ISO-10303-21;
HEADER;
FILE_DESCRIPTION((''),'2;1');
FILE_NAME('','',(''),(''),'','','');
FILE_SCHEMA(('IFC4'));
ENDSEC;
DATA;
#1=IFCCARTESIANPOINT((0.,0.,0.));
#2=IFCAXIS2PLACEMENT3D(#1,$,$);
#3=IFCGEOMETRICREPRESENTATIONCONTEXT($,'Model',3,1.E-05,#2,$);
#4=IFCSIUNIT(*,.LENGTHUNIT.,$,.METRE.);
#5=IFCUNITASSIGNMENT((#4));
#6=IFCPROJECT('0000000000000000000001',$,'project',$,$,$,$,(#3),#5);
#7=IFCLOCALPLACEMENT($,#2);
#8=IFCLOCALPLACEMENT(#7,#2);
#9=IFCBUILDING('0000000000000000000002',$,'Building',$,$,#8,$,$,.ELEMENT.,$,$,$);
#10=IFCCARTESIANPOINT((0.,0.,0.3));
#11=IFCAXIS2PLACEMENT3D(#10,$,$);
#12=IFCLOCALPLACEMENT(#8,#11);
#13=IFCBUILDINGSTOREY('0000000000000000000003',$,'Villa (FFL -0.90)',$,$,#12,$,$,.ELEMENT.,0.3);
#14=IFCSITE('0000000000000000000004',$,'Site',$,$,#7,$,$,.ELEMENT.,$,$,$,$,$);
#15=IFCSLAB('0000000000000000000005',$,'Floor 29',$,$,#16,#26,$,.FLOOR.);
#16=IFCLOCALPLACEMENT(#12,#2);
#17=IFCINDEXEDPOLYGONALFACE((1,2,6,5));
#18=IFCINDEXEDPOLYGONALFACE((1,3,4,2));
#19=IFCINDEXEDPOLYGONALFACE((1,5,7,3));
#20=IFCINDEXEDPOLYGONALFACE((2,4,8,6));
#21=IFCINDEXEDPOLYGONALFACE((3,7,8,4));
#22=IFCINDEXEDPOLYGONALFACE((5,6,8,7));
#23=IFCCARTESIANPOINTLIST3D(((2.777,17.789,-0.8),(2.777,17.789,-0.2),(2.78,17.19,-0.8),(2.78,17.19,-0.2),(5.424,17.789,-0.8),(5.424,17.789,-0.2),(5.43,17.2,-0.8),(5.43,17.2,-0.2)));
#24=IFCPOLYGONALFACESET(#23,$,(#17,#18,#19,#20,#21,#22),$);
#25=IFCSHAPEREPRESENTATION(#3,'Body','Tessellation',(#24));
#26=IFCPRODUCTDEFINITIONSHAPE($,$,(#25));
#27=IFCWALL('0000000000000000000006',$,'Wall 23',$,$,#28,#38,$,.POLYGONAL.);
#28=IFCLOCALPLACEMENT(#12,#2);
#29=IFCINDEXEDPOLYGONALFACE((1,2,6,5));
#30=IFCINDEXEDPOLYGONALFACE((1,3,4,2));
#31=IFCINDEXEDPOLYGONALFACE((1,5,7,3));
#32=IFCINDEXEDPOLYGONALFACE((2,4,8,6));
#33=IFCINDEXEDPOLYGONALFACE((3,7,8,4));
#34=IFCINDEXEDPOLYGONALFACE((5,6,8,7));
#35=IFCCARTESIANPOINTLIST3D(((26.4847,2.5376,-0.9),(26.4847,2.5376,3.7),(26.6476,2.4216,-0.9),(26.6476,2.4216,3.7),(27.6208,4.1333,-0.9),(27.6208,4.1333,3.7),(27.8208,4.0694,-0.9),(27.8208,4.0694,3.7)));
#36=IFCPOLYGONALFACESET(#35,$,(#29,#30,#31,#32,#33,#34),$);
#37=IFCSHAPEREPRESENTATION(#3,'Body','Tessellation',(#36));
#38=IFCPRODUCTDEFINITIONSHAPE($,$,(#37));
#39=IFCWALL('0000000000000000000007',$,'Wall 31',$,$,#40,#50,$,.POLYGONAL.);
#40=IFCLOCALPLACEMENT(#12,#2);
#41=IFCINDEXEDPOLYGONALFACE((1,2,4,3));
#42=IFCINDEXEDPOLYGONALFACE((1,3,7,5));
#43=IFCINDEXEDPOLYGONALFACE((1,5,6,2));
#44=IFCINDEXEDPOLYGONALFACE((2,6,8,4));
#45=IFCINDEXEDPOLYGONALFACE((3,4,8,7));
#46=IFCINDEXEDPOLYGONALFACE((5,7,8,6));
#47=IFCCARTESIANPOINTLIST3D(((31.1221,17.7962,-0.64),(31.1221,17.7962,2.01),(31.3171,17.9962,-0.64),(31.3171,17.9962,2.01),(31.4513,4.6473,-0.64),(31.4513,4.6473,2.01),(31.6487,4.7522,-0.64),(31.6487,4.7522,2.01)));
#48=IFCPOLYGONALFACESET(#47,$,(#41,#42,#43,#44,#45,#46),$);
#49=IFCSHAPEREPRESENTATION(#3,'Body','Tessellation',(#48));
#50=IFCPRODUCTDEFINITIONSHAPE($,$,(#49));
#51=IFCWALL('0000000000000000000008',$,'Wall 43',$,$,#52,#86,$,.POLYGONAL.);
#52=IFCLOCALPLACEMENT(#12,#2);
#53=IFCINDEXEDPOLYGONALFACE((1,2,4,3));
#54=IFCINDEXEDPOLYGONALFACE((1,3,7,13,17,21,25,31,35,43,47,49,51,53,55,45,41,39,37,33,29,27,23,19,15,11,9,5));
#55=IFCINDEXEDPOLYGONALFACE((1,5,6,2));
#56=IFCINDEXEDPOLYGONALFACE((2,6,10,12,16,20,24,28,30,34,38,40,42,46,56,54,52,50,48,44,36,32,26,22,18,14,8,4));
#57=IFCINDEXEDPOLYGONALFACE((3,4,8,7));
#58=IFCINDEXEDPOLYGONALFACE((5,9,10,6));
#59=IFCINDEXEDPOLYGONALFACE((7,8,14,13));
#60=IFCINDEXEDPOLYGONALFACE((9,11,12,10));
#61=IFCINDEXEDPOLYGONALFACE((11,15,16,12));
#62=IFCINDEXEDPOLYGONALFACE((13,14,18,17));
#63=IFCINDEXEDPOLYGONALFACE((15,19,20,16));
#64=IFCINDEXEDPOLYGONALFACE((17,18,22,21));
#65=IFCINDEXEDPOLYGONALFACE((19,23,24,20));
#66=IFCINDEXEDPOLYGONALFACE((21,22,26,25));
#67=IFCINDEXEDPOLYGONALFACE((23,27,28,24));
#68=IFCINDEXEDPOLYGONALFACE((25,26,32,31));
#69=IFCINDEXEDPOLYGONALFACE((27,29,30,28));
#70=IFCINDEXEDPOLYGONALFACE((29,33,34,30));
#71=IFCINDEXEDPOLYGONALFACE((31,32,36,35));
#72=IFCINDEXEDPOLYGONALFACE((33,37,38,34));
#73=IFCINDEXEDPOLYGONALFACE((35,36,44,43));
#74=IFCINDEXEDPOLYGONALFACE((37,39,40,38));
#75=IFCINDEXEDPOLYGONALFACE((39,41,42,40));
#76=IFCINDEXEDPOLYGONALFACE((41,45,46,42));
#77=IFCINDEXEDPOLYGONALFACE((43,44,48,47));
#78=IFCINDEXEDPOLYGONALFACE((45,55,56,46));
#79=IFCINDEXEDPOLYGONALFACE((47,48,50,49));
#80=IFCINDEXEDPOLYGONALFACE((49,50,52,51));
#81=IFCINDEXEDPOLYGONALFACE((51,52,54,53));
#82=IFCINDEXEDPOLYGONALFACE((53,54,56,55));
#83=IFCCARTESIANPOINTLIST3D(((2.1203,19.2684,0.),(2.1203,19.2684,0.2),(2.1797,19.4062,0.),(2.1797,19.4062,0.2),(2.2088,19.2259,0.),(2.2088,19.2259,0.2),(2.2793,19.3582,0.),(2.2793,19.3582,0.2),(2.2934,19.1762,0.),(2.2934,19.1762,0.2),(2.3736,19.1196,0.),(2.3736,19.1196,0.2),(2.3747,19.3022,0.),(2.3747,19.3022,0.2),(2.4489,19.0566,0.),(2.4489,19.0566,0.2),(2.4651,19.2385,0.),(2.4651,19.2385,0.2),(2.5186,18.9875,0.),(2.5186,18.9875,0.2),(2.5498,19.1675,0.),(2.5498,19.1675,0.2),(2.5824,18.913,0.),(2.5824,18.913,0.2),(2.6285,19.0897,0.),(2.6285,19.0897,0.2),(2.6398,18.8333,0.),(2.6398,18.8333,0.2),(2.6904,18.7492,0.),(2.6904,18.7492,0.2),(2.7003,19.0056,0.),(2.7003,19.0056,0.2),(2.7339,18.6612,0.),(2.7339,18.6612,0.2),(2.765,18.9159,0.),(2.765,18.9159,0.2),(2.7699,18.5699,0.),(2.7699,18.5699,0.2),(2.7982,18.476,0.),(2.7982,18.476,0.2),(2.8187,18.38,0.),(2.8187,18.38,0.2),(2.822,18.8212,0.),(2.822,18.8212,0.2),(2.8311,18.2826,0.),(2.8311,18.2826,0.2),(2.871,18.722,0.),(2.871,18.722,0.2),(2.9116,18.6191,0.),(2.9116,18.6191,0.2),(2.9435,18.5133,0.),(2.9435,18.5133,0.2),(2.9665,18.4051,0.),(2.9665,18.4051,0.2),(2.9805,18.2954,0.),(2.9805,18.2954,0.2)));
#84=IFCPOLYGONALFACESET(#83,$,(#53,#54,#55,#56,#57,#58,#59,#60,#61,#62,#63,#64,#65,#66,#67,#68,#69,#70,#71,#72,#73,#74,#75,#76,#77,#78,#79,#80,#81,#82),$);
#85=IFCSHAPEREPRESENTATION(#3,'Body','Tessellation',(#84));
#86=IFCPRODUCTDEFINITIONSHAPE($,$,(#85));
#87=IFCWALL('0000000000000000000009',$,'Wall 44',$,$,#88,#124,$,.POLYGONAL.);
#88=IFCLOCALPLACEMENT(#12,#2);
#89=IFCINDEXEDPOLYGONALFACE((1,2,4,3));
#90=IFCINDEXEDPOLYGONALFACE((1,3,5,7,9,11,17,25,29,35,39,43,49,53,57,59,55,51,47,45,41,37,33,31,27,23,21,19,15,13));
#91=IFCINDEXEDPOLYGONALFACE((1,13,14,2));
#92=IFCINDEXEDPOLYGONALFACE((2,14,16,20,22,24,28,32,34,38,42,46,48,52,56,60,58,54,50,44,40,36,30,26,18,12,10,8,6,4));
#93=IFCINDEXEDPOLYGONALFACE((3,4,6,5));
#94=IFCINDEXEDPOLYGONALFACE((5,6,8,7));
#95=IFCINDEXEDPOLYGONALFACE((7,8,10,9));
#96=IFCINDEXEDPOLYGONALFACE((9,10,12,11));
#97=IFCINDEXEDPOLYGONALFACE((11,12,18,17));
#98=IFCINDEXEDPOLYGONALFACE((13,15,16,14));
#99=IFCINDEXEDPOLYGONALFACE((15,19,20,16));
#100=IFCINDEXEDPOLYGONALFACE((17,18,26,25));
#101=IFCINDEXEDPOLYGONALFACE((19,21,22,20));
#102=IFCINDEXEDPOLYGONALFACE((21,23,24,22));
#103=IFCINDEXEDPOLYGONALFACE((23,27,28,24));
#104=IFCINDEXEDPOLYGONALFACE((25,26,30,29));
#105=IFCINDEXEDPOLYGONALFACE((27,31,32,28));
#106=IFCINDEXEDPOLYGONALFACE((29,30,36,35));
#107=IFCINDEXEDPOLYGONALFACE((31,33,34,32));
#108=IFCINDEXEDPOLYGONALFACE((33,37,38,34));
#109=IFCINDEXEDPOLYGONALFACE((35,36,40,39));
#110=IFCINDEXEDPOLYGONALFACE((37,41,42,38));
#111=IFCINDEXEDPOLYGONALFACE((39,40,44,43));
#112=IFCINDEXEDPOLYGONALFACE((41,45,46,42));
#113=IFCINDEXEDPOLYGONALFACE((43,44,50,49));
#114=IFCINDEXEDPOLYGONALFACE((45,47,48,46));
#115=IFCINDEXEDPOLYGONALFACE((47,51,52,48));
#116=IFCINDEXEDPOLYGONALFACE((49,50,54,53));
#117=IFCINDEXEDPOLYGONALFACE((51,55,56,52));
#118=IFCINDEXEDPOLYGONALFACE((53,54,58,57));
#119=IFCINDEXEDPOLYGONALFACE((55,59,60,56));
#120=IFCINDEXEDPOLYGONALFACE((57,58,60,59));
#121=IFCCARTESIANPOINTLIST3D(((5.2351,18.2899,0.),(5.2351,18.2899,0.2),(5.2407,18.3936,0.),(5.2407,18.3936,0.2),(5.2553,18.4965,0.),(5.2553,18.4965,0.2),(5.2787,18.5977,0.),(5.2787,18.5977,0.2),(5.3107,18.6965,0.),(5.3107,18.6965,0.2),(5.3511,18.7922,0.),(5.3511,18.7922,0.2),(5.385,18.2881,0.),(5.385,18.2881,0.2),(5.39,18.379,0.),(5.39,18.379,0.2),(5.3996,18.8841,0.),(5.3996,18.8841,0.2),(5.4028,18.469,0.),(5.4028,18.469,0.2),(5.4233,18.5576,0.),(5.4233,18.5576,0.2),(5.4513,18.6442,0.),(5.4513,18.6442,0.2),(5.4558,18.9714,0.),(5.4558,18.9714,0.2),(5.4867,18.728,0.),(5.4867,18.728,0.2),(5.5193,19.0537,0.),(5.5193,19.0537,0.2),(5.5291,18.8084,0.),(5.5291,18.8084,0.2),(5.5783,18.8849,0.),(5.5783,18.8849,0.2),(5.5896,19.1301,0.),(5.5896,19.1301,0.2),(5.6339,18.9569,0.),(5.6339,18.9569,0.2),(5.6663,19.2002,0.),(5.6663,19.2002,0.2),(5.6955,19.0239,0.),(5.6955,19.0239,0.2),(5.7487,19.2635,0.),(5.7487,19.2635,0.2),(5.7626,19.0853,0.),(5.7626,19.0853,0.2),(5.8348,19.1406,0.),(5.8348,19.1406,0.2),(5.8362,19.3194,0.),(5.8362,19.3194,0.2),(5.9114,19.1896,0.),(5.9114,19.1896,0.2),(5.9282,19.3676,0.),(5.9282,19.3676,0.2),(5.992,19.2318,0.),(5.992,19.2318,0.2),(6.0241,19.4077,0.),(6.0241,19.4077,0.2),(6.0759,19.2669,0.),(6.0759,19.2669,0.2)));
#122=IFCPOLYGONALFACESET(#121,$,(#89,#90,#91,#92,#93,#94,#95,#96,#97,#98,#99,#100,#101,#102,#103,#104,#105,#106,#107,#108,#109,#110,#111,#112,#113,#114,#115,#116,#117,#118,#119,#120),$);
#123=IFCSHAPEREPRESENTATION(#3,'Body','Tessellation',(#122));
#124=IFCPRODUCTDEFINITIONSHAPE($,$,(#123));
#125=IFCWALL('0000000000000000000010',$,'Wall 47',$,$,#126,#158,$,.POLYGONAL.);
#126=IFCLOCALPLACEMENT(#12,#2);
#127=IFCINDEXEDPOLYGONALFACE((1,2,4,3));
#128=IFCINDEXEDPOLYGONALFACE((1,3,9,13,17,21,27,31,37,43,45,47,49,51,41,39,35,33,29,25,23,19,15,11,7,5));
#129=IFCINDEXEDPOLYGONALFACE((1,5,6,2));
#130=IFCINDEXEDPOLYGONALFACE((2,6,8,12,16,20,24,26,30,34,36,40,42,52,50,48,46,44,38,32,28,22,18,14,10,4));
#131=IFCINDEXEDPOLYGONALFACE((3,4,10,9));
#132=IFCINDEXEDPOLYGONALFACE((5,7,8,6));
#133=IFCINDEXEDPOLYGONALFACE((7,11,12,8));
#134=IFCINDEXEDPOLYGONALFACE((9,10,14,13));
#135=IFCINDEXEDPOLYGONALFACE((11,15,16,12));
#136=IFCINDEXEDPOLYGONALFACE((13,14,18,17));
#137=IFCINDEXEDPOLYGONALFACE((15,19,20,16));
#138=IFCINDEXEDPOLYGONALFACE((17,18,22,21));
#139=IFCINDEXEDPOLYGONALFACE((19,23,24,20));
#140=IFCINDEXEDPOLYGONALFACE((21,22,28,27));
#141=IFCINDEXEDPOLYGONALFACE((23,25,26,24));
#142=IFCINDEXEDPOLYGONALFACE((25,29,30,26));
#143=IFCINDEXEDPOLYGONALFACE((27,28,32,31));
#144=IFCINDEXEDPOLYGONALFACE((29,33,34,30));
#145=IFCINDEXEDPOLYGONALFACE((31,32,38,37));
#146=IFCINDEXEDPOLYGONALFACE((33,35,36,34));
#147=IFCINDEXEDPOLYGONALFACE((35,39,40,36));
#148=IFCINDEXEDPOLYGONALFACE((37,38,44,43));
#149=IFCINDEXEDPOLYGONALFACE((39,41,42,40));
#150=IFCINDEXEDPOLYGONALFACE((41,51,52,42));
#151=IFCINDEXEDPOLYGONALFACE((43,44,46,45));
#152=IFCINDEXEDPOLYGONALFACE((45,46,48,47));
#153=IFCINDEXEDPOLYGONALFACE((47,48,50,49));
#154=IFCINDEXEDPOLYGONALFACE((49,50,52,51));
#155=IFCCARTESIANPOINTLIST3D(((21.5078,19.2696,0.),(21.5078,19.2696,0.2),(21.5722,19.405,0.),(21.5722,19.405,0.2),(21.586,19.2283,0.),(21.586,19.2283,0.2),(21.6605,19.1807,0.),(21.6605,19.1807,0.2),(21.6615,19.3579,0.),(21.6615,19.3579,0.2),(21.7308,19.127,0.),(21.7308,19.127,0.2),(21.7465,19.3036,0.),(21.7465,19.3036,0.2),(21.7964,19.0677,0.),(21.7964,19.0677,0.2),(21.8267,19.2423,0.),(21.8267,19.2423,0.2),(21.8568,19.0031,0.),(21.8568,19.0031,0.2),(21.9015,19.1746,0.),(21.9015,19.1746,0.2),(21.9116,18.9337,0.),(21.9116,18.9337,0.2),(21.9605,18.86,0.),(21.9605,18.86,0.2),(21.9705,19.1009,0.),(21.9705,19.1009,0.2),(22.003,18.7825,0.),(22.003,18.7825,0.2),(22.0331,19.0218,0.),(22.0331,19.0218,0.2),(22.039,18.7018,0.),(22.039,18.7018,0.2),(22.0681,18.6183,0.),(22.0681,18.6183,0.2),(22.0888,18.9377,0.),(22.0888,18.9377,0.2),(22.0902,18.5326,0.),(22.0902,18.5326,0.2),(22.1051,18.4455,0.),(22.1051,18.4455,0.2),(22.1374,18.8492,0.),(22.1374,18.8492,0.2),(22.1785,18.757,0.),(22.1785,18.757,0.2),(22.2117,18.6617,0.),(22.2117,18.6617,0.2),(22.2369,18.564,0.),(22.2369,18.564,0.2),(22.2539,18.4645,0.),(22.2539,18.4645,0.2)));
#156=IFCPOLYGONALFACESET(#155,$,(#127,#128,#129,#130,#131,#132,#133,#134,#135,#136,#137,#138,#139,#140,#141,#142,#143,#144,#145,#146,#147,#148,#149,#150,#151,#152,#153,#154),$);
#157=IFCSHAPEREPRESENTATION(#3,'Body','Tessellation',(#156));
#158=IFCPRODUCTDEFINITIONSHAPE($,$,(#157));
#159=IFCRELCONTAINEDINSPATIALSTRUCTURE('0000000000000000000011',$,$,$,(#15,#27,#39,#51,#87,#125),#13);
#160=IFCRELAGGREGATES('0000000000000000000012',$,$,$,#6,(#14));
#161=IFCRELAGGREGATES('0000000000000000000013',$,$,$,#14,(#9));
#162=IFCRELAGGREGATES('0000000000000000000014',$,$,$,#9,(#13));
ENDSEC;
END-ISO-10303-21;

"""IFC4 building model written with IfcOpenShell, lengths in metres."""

from ifc_helpers import new_model, si_unit, frame, origin, origin_with_axes, place, context, project, spatial, polyline, outline, extrude, element, save


model = new_model("IFC4")

# Units and contexts
model_context = context("Model", 3, precision=1e-05, world=origin())
ifc_project = project(units=[si_unit("LENGTHUNIT", "METRE")], contexts=[model_context])

# Site, building, storey
site_placement = place(None, origin())
site = spatial("IfcSite", under=ifc_project, at=site_placement, Name="Site", CompositionType="ELEMENT")
building_placement = place(site_placement, origin())
building = spatial("IfcBuilding", under=site, at=building_placement, Name="Building", CompositionType="ELEMENT")
storey_placement = place(building_placement, frame((0.0, 0.0, 0.3)))
storey = spatial("IfcBuildingStorey", under=building, at=storey_placement, Name="Villa (FFL -0.90)", CompositionType="ELEMENT", Elevation=0.3)

# Slab
slab_1_placement = place(storey_placement, frame((0.0, 0.0, -0.8), z_axis=(0.0, 0.0, 1.0), x_axis=(1.0, 0.0, 0.0)))
element("IfcSlab", 1, at=slab_1_placement, inside=storey, Name="Floor 29", PredefinedType="FLOOR", context=model_context, shape_type="SweptSolid", body=[
    extrude(outline(polyline([(5.424, 17.789), (5.43, 17.2), (2.78, 17.19), (2.777, 17.789), (5.424, 17.789)])), origin(), (0.0, 0.0, 1.0), 0.6),
])

# Walls
wall_1_placement = place(storey_placement, frame((0.0, 0.0, -0.9), z_axis=(0.0, 0.0, 1.0), x_axis=(1.0, 0.0, 0.0)))
element("IfcWall", 2, at=wall_1_placement, inside=storey, Name="Wall 23", PredefinedType="POLYGONAL", context=model_context, shape_type="SweptSolid", body=[
    extrude(outline(polyline([(26.4847, 2.5376), (26.6476, 2.4216), (27.8208, 4.0694), (27.6208, 4.1333), (26.4847, 2.5376)])), origin(), (0.0, 0.0, 1.0), 4.6),
])
wall_2_placement = place(storey_placement, frame((0.0, 0.0, -0.64), z_axis=(0.0, 0.0, 1.0), x_axis=(1.0, 0.0, 0.0)))
element("IfcWall", 3, at=wall_2_placement, inside=storey, Name="Wall 31", PredefinedType="POLYGONAL", context=model_context, shape_type="SweptSolid", body=[
    extrude(outline(polyline([(31.3171, 17.9962), (31.1221, 17.7962), (31.4513, 4.6473), (31.6487, 4.7522), (31.3171, 17.9962)])), origin(), (0.0, 0.0, 1.0), 2.65),
])
wall_3_placement = place(storey_placement, origin_with_axes())
element("IfcWall", 4, at=wall_3_placement, inside=storey, Name="Wall 43", PredefinedType="POLYGONAL", context=model_context, shape_type="SweptSolid", body=[
    extrude(outline(polyline([(2.9805, 18.2954), (2.9665, 18.4051), (2.9435, 18.5133), (2.9116, 18.6191), (2.871, 18.722), (2.822, 18.8212), (2.765, 18.9159), (2.7003, 19.0056), (2.6285, 19.0897), (2.5499, 19.1675), (2.4651, 19.2385), (2.3747, 19.3022), (2.2793, 19.3582), (2.1797, 19.4062), (2.1203, 19.2684), (2.2088, 19.2259), (2.2934, 19.1762), (2.3736, 19.1196), (2.4489, 19.0566), (2.5186, 18.9875), (2.5824, 18.913), (2.6398, 18.8333), (2.6904, 18.7492), (2.7339, 18.6612), (2.7699, 18.5699), (2.7982, 18.476), (2.8187, 18.38), (2.8311, 18.2826), (2.9805, 18.2954)])), origin(), (0.0, 0.0, 1.0), 0.2),
])
wall_4_placement = place(storey_placement, origin_with_axes())
element("IfcWall", 5, at=wall_4_placement, inside=storey, Name="Wall 44", PredefinedType="POLYGONAL", context=model_context, shape_type="SweptSolid", body=[
    extrude(outline(polyline([(5.2351, 18.2899), (5.2407, 18.3936), (5.2553, 18.4965), (5.2787, 18.5977), (5.3107, 18.6965), (5.3511, 18.7922), (5.3996, 18.8841), (5.4558, 18.9714), (5.5193, 19.0537), (5.5896, 19.1301), (5.6663, 19.2002), (5.7487, 19.2635), (5.8362, 19.3194), (5.9282, 19.3676), (6.0241, 19.4077), (6.0759, 19.2669), (5.992, 19.2318), (5.9114, 19.1896), (5.8348, 19.1406), (5.7626, 19.0853), (5.6955, 19.0239), (5.6339, 18.9569), (5.5783, 18.8849), (5.5291, 18.8084), (5.4867, 18.728), (5.4513, 18.6442), (5.4233, 18.5576), (5.4028, 18.469), (5.39, 18.3789), (5.385, 18.2881), (5.2351, 18.2899)])), origin(), (0.0, 0.0, 1.0), 0.2),
])
wall_5_placement = place(storey_placement, origin_with_axes())
element("IfcWall", 6, at=wall_5_placement, inside=storey, Name="Wall 47", PredefinedType="POLYGONAL", context=model_context, shape_type="SweptSolid", body=[
    extrude(outline(polyline([(22.2539, 18.4645), (22.2369, 18.564), (22.2117, 18.6617), (22.1785, 18.757), (22.1374, 18.8492), (22.0888, 18.9377), (22.0331, 19.0218), (21.9705, 19.1009), (21.9015, 19.1746), (21.8267, 19.2423), (21.7465, 19.3036), (21.6615, 19.3579), (21.5722, 19.405), (21.5078, 19.2696), (21.586, 19.2283), (21.6605, 19.1807), (21.7308, 19.127), (21.7964, 19.0677), (21.8568, 19.0031), (21.9116, 18.9337), (21.9605, 18.86), (22.003, 18.7825), (22.039, 18.7018), (22.0681, 18.6183), (22.0902, 18.5326), (22.1051, 18.4455), (22.2539, 18.4645)])), origin(), (0.0, 0.0, 1.0), 0.2),
])

save(model, "model.ifc")
